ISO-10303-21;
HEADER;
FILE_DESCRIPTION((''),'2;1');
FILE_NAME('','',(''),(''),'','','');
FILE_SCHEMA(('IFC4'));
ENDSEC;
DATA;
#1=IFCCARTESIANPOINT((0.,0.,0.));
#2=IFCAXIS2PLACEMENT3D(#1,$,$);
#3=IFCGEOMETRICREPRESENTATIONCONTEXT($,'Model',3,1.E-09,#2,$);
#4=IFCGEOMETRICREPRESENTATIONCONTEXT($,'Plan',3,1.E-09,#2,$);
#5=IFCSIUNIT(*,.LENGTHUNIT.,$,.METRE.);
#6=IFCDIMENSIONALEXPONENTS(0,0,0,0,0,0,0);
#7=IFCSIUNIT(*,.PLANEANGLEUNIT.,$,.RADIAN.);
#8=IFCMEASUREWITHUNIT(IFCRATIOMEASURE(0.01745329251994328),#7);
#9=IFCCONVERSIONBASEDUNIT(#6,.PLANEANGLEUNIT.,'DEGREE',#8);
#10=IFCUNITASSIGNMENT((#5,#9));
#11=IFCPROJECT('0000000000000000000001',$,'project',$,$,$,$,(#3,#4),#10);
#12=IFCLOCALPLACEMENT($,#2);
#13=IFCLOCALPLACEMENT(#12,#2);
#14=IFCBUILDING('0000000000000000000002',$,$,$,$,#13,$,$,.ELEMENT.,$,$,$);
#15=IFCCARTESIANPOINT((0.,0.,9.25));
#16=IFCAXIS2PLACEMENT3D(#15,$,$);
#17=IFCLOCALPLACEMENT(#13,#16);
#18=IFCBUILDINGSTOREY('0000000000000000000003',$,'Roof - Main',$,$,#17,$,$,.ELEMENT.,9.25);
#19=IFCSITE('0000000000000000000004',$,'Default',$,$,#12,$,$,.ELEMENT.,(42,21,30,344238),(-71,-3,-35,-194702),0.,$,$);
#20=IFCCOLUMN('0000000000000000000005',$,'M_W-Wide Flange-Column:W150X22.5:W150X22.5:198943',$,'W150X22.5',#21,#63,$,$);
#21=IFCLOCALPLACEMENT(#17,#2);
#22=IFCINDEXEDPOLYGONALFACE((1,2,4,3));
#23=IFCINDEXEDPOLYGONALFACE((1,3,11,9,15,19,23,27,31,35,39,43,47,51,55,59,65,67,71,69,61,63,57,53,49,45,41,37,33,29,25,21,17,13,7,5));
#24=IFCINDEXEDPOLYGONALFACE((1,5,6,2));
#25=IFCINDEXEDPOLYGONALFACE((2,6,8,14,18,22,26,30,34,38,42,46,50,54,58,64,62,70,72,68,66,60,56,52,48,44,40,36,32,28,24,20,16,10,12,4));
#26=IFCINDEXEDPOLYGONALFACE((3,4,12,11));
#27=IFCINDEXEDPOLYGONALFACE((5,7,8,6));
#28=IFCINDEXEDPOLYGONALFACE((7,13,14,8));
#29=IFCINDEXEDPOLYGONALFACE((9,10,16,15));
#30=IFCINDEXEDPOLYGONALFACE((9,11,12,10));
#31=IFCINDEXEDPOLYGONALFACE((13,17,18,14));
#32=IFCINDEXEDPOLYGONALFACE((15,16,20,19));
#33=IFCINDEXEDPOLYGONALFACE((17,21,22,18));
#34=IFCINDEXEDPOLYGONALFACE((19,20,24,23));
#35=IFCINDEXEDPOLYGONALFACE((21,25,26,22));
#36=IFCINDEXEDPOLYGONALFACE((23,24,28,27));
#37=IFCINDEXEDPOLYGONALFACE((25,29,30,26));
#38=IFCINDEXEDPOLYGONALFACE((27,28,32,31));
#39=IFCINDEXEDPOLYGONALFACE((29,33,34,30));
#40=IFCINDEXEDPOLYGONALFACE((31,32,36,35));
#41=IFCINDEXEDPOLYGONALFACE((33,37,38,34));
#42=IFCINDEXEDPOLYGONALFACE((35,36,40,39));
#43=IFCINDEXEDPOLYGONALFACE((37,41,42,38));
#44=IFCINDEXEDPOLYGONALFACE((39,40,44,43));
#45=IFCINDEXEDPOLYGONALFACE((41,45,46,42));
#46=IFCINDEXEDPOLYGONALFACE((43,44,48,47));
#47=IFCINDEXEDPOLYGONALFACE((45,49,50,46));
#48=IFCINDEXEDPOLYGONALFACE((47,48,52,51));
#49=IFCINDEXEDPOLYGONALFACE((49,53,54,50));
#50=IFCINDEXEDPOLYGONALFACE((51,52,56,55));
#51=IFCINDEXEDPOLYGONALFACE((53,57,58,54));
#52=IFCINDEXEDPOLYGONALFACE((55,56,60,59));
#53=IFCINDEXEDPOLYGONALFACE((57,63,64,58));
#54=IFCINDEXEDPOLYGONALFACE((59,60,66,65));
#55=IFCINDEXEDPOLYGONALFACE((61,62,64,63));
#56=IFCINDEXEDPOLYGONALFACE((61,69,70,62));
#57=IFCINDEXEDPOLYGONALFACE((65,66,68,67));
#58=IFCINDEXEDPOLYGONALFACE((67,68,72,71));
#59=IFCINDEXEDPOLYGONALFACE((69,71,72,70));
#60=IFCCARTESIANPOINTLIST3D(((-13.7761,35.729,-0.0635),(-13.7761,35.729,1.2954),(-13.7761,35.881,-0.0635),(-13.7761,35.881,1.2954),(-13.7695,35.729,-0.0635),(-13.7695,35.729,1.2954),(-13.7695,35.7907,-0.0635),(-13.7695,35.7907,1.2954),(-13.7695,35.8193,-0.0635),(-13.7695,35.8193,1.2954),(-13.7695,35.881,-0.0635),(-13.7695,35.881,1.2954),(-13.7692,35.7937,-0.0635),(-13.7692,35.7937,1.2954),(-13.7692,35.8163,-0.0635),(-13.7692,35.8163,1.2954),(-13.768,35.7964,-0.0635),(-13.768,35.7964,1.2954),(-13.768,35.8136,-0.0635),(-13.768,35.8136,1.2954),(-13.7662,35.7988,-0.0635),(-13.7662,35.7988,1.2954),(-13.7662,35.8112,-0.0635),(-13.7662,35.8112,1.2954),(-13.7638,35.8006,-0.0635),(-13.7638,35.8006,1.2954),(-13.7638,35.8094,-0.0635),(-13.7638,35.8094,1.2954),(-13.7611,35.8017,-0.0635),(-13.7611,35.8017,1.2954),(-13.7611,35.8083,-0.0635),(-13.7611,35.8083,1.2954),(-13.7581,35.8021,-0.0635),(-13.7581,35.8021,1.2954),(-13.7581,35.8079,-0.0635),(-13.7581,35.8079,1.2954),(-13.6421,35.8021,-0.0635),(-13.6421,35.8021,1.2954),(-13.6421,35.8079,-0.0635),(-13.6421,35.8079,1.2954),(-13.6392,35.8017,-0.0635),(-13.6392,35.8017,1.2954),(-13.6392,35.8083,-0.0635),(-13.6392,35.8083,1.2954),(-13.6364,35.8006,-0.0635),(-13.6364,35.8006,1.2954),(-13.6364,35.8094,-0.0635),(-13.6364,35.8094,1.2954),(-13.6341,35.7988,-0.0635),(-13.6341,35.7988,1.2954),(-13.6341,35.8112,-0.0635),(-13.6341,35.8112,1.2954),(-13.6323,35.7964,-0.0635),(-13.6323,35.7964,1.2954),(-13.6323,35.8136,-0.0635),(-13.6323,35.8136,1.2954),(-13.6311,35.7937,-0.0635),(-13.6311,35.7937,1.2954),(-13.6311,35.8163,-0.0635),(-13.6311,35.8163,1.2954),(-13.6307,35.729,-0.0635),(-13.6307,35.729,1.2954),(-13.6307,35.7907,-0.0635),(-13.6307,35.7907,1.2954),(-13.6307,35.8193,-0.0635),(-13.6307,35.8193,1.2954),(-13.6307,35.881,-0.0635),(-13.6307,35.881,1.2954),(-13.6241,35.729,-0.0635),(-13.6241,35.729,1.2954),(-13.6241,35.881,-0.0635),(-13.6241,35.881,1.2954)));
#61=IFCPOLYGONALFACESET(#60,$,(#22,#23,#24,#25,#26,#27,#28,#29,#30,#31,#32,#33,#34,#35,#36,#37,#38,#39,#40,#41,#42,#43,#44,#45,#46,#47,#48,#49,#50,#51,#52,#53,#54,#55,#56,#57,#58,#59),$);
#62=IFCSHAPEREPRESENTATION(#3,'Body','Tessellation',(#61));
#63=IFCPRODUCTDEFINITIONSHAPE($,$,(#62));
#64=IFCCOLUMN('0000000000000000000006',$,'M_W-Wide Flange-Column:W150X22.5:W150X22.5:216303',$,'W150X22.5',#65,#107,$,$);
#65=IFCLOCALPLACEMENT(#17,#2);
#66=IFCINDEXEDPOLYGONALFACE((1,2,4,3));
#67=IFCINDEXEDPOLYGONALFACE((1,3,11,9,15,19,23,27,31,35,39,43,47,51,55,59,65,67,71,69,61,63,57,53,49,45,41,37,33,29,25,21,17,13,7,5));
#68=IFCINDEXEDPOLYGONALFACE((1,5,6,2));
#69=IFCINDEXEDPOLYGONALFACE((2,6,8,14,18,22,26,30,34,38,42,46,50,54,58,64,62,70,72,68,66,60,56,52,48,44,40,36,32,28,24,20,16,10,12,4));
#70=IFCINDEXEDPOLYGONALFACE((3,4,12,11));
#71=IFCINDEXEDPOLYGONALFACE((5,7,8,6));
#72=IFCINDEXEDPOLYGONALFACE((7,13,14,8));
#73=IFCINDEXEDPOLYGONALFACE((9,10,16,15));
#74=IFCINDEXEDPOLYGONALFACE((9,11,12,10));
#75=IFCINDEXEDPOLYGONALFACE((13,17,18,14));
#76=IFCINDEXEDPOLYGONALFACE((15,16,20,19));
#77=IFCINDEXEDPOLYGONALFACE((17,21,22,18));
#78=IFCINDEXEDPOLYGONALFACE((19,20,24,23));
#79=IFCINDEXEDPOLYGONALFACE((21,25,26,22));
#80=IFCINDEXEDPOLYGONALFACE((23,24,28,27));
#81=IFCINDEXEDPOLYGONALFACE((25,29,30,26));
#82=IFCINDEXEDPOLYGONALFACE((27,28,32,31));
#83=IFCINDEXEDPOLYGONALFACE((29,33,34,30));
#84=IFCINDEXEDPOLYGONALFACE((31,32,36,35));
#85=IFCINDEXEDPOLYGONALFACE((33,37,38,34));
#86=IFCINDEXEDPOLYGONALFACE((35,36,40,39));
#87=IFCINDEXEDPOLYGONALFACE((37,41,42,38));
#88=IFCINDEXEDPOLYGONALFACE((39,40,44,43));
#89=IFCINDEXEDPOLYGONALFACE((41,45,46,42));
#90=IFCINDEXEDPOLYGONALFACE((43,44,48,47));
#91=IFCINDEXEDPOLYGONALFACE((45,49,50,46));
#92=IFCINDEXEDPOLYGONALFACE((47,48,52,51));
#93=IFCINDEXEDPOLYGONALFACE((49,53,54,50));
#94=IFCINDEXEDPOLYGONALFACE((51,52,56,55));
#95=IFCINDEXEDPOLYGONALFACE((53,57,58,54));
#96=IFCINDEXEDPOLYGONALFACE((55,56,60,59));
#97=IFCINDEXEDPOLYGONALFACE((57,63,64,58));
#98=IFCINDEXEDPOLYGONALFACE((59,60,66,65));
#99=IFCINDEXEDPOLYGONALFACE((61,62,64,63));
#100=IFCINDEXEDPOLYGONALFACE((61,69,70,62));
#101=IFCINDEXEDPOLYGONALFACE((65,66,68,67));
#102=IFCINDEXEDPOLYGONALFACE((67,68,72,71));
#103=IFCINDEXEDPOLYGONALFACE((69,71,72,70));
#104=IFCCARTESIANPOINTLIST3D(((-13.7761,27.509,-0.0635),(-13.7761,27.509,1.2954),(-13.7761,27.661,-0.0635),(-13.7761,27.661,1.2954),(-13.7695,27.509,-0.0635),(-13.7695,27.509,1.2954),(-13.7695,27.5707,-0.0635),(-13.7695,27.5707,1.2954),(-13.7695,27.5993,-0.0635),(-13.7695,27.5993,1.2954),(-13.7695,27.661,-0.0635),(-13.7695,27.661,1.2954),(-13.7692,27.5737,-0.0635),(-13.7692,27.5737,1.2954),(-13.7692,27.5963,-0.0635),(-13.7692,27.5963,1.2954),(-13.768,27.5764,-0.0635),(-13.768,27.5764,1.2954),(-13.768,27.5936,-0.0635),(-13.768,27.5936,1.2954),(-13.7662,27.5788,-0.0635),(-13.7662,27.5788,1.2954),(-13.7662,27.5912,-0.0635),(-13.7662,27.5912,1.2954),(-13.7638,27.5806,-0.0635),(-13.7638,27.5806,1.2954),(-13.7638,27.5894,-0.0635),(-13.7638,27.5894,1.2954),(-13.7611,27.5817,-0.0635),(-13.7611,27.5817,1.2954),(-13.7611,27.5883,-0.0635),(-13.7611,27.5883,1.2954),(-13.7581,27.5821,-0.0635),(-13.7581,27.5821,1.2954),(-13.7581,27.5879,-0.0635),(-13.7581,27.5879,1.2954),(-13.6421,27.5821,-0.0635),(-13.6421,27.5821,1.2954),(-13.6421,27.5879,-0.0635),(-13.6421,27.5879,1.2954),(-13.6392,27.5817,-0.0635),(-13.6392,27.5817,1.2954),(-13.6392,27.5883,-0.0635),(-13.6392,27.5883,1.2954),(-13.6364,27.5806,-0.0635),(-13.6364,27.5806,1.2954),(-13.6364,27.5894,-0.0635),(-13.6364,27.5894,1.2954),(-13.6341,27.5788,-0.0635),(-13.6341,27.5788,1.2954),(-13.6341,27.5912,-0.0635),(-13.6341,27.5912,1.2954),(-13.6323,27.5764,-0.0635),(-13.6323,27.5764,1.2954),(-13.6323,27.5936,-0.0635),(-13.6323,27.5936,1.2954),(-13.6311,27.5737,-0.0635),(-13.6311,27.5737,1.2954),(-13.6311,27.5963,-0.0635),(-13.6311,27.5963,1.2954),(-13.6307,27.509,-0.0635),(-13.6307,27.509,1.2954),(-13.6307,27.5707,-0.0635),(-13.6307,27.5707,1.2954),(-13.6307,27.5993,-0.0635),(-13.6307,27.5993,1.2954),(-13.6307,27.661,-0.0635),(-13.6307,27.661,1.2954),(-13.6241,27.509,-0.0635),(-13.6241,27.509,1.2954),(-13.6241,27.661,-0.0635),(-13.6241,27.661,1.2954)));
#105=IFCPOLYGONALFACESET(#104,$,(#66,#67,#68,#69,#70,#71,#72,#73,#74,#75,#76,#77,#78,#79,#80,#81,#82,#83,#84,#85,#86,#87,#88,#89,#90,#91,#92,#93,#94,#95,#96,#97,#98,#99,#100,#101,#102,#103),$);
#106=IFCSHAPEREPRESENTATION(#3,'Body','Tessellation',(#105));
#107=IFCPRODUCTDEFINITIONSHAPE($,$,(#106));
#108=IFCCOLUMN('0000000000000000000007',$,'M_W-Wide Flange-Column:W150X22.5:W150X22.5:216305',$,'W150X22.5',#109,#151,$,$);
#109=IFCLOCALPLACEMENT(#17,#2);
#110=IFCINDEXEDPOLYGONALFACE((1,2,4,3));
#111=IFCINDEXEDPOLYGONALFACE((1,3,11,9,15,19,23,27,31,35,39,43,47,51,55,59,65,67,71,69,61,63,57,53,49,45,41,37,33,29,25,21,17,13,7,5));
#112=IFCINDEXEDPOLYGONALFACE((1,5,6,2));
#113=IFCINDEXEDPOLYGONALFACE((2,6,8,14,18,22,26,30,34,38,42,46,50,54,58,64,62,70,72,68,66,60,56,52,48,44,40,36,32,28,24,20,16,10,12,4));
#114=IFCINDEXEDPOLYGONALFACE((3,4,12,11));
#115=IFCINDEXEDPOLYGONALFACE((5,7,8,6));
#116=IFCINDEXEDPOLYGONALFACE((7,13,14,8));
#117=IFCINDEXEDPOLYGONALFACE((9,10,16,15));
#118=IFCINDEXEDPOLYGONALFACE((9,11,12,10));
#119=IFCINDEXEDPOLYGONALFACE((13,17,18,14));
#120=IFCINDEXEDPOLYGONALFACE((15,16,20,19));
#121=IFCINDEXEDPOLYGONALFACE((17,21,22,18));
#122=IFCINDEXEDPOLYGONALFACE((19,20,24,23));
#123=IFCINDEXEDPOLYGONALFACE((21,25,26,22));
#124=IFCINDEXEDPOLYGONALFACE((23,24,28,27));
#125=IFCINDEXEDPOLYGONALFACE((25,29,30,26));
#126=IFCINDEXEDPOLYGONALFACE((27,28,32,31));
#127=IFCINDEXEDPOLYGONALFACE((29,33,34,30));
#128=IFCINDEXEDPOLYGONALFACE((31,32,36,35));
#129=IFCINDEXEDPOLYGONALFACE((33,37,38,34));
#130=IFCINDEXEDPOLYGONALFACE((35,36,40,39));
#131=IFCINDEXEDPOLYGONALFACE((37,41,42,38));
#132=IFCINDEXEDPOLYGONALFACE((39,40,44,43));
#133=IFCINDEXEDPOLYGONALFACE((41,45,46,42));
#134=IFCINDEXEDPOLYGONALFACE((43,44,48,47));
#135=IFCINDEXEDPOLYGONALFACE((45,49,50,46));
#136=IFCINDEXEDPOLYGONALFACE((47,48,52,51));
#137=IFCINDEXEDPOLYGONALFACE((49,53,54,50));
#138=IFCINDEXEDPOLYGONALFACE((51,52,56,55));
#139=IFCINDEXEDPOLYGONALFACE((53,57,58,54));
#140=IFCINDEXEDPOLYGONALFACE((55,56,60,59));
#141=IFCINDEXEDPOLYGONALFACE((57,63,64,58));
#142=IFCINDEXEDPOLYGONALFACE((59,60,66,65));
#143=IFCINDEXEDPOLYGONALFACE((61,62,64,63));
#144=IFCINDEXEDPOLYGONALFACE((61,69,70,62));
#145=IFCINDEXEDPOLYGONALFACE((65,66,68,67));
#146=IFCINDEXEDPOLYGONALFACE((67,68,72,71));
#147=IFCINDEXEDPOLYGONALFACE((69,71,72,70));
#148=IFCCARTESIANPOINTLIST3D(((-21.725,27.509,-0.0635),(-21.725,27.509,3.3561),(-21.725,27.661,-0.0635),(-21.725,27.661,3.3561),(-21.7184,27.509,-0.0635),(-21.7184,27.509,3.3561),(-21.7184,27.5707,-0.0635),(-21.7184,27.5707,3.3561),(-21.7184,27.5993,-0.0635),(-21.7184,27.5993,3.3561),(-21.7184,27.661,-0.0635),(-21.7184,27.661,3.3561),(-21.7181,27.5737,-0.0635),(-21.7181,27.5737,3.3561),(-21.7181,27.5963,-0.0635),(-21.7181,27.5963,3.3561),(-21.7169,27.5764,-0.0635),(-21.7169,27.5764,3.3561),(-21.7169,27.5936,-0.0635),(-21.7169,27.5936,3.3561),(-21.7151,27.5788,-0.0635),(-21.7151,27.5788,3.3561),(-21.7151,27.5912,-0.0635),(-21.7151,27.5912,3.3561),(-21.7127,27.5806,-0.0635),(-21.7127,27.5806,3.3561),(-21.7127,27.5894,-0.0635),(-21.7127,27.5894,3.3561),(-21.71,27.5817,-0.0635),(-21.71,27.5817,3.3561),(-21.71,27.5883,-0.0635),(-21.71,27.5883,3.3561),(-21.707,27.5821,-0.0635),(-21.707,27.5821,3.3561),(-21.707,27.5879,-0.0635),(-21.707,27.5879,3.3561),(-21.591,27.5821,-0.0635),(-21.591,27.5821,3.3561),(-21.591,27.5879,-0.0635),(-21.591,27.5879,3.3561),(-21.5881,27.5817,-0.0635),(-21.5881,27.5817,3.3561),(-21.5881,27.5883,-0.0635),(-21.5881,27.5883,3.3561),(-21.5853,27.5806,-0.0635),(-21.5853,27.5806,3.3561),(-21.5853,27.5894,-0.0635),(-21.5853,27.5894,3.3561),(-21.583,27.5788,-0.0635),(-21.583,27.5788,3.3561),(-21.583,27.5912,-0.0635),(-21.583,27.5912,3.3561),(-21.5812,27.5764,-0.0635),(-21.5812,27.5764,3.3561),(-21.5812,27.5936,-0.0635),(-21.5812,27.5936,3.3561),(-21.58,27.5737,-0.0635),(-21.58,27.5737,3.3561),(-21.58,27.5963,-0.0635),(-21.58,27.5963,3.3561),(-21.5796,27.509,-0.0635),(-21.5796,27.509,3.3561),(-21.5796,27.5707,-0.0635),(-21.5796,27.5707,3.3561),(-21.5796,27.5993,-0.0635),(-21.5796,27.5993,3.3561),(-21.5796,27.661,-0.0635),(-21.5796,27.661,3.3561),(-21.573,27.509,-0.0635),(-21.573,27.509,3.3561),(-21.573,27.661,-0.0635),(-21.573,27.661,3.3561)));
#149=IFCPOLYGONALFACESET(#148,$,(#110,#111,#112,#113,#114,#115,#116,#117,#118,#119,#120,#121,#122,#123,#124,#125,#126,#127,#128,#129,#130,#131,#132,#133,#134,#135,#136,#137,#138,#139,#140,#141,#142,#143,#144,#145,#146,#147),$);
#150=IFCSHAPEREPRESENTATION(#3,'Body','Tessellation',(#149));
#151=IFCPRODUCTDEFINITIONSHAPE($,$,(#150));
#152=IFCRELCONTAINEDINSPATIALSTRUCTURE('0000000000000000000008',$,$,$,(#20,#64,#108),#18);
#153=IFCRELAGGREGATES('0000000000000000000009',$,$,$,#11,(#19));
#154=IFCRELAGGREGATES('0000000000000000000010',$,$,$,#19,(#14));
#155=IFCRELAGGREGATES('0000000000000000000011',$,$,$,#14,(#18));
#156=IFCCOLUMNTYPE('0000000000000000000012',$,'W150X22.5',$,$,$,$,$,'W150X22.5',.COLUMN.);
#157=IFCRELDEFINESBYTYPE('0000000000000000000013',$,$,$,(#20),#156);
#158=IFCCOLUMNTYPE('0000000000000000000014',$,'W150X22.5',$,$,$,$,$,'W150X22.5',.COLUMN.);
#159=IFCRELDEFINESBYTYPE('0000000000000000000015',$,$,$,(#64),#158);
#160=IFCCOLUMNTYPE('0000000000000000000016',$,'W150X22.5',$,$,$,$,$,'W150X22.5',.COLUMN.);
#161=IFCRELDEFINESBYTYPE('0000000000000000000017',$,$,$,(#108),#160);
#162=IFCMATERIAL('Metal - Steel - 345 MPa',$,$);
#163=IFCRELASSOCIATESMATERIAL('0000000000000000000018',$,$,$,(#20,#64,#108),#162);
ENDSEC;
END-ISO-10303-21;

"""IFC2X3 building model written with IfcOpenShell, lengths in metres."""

from ifc_helpers import new_model, entity, si_unit, converted_unit, frame, frame_2d, origin, place, context, project, spatial, polyline, circle_curve, parameter, trimmed, segment, composite_curve, outline, extrude, source, transform, mapped, material, type_object, type_shapes, element, save


model = new_model("IFC2X3")

# Units and contexts
model_context = context("Model", 3, precision=1e-09, world=origin())
plan_context = context("Plan", 3, precision=1e-09, world=origin())
ifc_project = project(units=[si_unit("LENGTHUNIT", "METRE"), converted_unit("PLANEANGLEUNIT", "DEGREE", entity("IfcRatioMeasure", 0.01745329251994328), si_unit("PLANEANGLEUNIT", "RADIAN"), dimensions=[0, 0, 0, 0, 0, 0, 0])], contexts=[model_context, plan_context])

# Site, building, storey
site_placement = place(None, origin())
site = spatial("IfcSite", under=ifc_project, at=site_placement, Name="Default", CompositionType="ELEMENT", RefLatitude=(42, 21, 30, 344238), RefLongitude=(-71, -3, -35, -194702), RefElevation=0.0)
building_placement = place(site_placement, origin())
building = spatial("IfcBuilding", under=site, at=building_placement, CompositionType="ELEMENT")
storey_placement = place(building_placement, frame((0.0, 0.0, 9.25)))
storey = spatial("IfcBuildingStorey", under=building, at=storey_placement, Name="Roof - Main", CompositionType="ELEMENT", Elevation=9.25)

# Columns
ifc_material_1 = material(Name="Metal - Steel - 345 MPa")
column_type_1 = type_object("IfcColumnType", Name="W150X22.5", ElementType="W150X22.5", PredefinedType="COLUMN")
shared_shape_1 = source(origin(), model_context, "Body", "SweptSolid", [
    extrude(outline(composite_curve([segment(polyline([(-0.076, -0.076), (0.076, -0.076)]), True, "CONTINUOUS"), segment(polyline([(0.076, -0.076), (0.076, -0.0694)]), True, "CONTINUOUS"), segment(polyline([(0.076, -0.0694), (0.0143, -0.0694)]), True, "CONTINUOUS"), segment(trimmed(circle_curve(frame_2d((0.0143, -0.058), x_axis=(-1.0, 0.0)), 0.0114), [parameter(0.0)], [parameter(90.0)], True, "PARAMETER"), False, "CONTINUOUS"), segment(polyline([(0.0029, -0.058), (0.0029, 0.058)]), True, "CONTINUOUS"), segment(trimmed(circle_curve(frame_2d((0.0143, 0.058), x_axis=(-1.0, 0.0)), 0.0114), [parameter(270.0)], [parameter(0.0)], True, "PARAMETER"), False, "CONTINUOUS"), segment(polyline([(0.0143, 0.0694), (0.076, 0.0694)]), True, "CONTINUOUS"), segment(polyline([(0.076, 0.0694), (0.076, 0.076)]), True, "CONTINUOUS"), segment(polyline([(0.076, 0.076), (-0.076, 0.076)]), True, "CONTINUOUS"), segment(polyline([(-0.076, 0.076), (-0.076, 0.0694)]), True, "CONTINUOUS"), segment(polyline([(-0.076, 0.0694), (-0.0143, 0.0694)]), True, "CONTINUOUS"), segment(trimmed(circle_curve(frame_2d((-0.0143, 0.058), x_axis=(-1.0, 0.0)), 0.0114), [parameter(180.0)], [parameter(270.0)], True, "PARAMETER"), False, "CONTINUOUS"), segment(polyline([(-0.0029, 0.058), (-0.0029, -0.058)]), True, "CONTINUOUS"), segment(trimmed(circle_curve(frame_2d((-0.0143, -0.058), x_axis=(-1.0, 0.0)), 0.0114), [parameter(90.0)], [parameter(180.0)], True, "PARAMETER"), False, "CONTINUOUS"), segment(polyline([(-0.0143, -0.0694), (-0.076, -0.0694)]), True, "CONTINUOUS"), segment(polyline([(-0.076, -0.0694), (-0.076, -0.076)]), True, "CONTINUOUS")], self_intersect=False)), frame((0.0, 0.0, 9.1865), z_axis=(0.0, 0.0, 1.0), x_axis=(-1.0, 0.0, 0.0)), (0.0, 0.0, 1.0), 1.3589),
])
type_shapes(column_type_1, [shared_shape_1])
column_1_placement = place(storey_placement, frame((-13.7001, 35.805, -9.25), z_axis=(0.0, 0.0, 1.0), x_axis=(0.0, 1.0, 0.0)))
element("IfcColumn", 1, at=column_1_placement, inside=storey, type_object=column_type_1, material=ifc_material_1, Name="M_W-Wide Flange-Column:W150X22.5:W150X22.5:198943", ObjectType="W150X22.5", context=model_context, shape_type="MappedRepresentation", body=[
    mapped(shared_shape_1, transform((0.0, 0.0, 0.0), scale=1.0)),
])
column_type_2 = type_object("IfcColumnType", Name="W150X22.5", ElementType="W150X22.5", PredefinedType="COLUMN")
shared_shape_2 = source(origin(), model_context, "Body", "SweptSolid", [
    extrude(outline(composite_curve([segment(polyline([(-0.076, -0.076), (-0.0694, -0.076)]), True, "CONTINUOUS"), segment(polyline([(-0.0694, -0.076), (-0.0694, -0.0143)]), True, "CONTINUOUS"), segment(trimmed(circle_curve(frame_2d((-0.058, -0.0143), x_axis=(0.0, -1.0)), 0.0114), [parameter(180.0)], [parameter(270.0)], True, "PARAMETER"), False, "CONTINUOUS"), segment(polyline([(-0.058, -0.0029), (0.058, -0.0029)]), True, "CONTINUOUS"), segment(trimmed(circle_curve(frame_2d((0.058, -0.0143), x_axis=(0.0, -1.0)), 0.0114), [parameter(90.0)], [parameter(180.0)], True, "PARAMETER"), False, "CONTINUOUS"), segment(polyline([(0.0694, -0.0143), (0.0694, -0.076)]), True, "CONTINUOUS"), segment(polyline([(0.0694, -0.076), (0.076, -0.076)]), True, "CONTINUOUS"), segment(polyline([(0.076, -0.076), (0.076, 0.076)]), True, "CONTINUOUS"), segment(polyline([(0.076, 0.076), (0.0694, 0.076)]), True, "CONTINUOUS"), segment(polyline([(0.0694, 0.076), (0.0694, 0.0143)]), True, "CONTINUOUS"), segment(trimmed(circle_curve(frame_2d((0.058, 0.0143), x_axis=(0.0, -1.0)), 0.0114), [parameter(360.0)], [parameter(90.0)], True, "PARAMETER"), False, "CONTINUOUS"), segment(polyline([(0.058, 0.0029), (-0.058, 0.0029)]), True, "CONTINUOUS"), segment(trimmed(circle_curve(frame_2d((-0.058, 0.0143), x_axis=(0.0, -1.0)), 0.0114), [parameter(270.0)], [parameter(360.0)], True, "PARAMETER"), False, "CONTINUOUS"), segment(polyline([(-0.0694, 0.0143), (-0.0694, 0.076)]), True, "CONTINUOUS"), segment(polyline([(-0.0694, 0.076), (-0.076, 0.076)]), True, "CONTINUOUS"), segment(polyline([(-0.076, 0.076), (-0.076, -0.076)]), True, "CONTINUOUS")], self_intersect=False)), frame((0.0, 0.0, 9.1865), z_axis=(0.0, 0.0, 1.0), x_axis=(0.0, 1.0, 0.0)), (0.0, 0.0, 1.0), 1.3589),
])
type_shapes(column_type_2, [shared_shape_2])
column_2_placement = place(storey_placement, frame((-13.7001, 27.585, -9.25), z_axis=(0.0, 0.0, 1.0), x_axis=(0.0, -1.0, 0.0)))
element("IfcColumn", 2, at=column_2_placement, inside=storey, type_object=column_type_2, material=ifc_material_1, Name="M_W-Wide Flange-Column:W150X22.5:W150X22.5:216303", ObjectType="W150X22.5", context=model_context, shape_type="MappedRepresentation", body=[
    mapped(shared_shape_2, transform((0.0, 0.0, 0.0), scale=1.0)),
])
column_type_3 = type_object("IfcColumnType", Name="W150X22.5", ElementType="W150X22.5", PredefinedType="COLUMN")
shared_shape_3 = source(origin(), model_context, "Body", "SweptSolid", [
    extrude(outline(composite_curve([segment(polyline([(-0.076, -0.076), (-0.0694, -0.076)]), True, "CONTINUOUS"), segment(polyline([(-0.0694, -0.076), (-0.0694, -0.0143)]), True, "CONTINUOUS"), segment(trimmed(circle_curve(frame_2d((-0.058, -0.0143), x_axis=(0.0, -1.0)), 0.0114), [parameter(180.0)], [parameter(270.0)], True, "PARAMETER"), False, "CONTINUOUS"), segment(polyline([(-0.058, -0.0029), (0.058, -0.0029)]), True, "CONTINUOUS"), segment(trimmed(circle_curve(frame_2d((0.058, -0.0143), x_axis=(0.0, -1.0)), 0.0114), [parameter(90.0)], [parameter(180.0)], True, "PARAMETER"), False, "CONTINUOUS"), segment(polyline([(0.0694, -0.0143), (0.0694, -0.076)]), True, "CONTINUOUS"), segment(polyline([(0.0694, -0.076), (0.076, -0.076)]), True, "CONTINUOUS"), segment(polyline([(0.076, -0.076), (0.076, 0.076)]), True, "CONTINUOUS"), segment(polyline([(0.076, 0.076), (0.0694, 0.076)]), True, "CONTINUOUS"), segment(polyline([(0.0694, 0.076), (0.0694, 0.0143)]), True, "CONTINUOUS"), segment(trimmed(circle_curve(frame_2d((0.058, 0.0143), x_axis=(0.0, -1.0)), 0.0114), [parameter(360.0)], [parameter(90.0)], True, "PARAMETER"), False, "CONTINUOUS"), segment(polyline([(0.058, 0.0029), (-0.058, 0.0029)]), True, "CONTINUOUS"), segment(trimmed(circle_curve(frame_2d((-0.058, 0.0143), x_axis=(0.0, -1.0)), 0.0114), [parameter(270.0)], [parameter(360.0)], True, "PARAMETER"), False, "CONTINUOUS"), segment(polyline([(-0.0694, 0.0143), (-0.0694, 0.076)]), True, "CONTINUOUS"), segment(polyline([(-0.0694, 0.076), (-0.076, 0.076)]), True, "CONTINUOUS"), segment(polyline([(-0.076, 0.076), (-0.076, -0.076)]), True, "CONTINUOUS")], self_intersect=False)), frame((0.0, 0.0, 9.1865), z_axis=(0.0, 0.0, 1.0), x_axis=(0.0, 1.0, 0.0)), (0.0, 0.0, 1.0), 3.4196),
])
type_shapes(column_type_3, [shared_shape_3])
column_3_placement = place(storey_placement, frame((-21.649, 27.585, -9.25), z_axis=(0.0, 0.0, 1.0), x_axis=(0.0, -1.0, 0.0)))
element("IfcColumn", 3, at=column_3_placement, inside=storey, type_object=column_type_3, material=ifc_material_1, Name="M_W-Wide Flange-Column:W150X22.5:W150X22.5:216305", ObjectType="W150X22.5", context=model_context, shape_type="MappedRepresentation", body=[
    mapped(shared_shape_3, transform((0.0, 0.0, 0.0), scale=1.0)),
])

save(model, "model.ifc")
